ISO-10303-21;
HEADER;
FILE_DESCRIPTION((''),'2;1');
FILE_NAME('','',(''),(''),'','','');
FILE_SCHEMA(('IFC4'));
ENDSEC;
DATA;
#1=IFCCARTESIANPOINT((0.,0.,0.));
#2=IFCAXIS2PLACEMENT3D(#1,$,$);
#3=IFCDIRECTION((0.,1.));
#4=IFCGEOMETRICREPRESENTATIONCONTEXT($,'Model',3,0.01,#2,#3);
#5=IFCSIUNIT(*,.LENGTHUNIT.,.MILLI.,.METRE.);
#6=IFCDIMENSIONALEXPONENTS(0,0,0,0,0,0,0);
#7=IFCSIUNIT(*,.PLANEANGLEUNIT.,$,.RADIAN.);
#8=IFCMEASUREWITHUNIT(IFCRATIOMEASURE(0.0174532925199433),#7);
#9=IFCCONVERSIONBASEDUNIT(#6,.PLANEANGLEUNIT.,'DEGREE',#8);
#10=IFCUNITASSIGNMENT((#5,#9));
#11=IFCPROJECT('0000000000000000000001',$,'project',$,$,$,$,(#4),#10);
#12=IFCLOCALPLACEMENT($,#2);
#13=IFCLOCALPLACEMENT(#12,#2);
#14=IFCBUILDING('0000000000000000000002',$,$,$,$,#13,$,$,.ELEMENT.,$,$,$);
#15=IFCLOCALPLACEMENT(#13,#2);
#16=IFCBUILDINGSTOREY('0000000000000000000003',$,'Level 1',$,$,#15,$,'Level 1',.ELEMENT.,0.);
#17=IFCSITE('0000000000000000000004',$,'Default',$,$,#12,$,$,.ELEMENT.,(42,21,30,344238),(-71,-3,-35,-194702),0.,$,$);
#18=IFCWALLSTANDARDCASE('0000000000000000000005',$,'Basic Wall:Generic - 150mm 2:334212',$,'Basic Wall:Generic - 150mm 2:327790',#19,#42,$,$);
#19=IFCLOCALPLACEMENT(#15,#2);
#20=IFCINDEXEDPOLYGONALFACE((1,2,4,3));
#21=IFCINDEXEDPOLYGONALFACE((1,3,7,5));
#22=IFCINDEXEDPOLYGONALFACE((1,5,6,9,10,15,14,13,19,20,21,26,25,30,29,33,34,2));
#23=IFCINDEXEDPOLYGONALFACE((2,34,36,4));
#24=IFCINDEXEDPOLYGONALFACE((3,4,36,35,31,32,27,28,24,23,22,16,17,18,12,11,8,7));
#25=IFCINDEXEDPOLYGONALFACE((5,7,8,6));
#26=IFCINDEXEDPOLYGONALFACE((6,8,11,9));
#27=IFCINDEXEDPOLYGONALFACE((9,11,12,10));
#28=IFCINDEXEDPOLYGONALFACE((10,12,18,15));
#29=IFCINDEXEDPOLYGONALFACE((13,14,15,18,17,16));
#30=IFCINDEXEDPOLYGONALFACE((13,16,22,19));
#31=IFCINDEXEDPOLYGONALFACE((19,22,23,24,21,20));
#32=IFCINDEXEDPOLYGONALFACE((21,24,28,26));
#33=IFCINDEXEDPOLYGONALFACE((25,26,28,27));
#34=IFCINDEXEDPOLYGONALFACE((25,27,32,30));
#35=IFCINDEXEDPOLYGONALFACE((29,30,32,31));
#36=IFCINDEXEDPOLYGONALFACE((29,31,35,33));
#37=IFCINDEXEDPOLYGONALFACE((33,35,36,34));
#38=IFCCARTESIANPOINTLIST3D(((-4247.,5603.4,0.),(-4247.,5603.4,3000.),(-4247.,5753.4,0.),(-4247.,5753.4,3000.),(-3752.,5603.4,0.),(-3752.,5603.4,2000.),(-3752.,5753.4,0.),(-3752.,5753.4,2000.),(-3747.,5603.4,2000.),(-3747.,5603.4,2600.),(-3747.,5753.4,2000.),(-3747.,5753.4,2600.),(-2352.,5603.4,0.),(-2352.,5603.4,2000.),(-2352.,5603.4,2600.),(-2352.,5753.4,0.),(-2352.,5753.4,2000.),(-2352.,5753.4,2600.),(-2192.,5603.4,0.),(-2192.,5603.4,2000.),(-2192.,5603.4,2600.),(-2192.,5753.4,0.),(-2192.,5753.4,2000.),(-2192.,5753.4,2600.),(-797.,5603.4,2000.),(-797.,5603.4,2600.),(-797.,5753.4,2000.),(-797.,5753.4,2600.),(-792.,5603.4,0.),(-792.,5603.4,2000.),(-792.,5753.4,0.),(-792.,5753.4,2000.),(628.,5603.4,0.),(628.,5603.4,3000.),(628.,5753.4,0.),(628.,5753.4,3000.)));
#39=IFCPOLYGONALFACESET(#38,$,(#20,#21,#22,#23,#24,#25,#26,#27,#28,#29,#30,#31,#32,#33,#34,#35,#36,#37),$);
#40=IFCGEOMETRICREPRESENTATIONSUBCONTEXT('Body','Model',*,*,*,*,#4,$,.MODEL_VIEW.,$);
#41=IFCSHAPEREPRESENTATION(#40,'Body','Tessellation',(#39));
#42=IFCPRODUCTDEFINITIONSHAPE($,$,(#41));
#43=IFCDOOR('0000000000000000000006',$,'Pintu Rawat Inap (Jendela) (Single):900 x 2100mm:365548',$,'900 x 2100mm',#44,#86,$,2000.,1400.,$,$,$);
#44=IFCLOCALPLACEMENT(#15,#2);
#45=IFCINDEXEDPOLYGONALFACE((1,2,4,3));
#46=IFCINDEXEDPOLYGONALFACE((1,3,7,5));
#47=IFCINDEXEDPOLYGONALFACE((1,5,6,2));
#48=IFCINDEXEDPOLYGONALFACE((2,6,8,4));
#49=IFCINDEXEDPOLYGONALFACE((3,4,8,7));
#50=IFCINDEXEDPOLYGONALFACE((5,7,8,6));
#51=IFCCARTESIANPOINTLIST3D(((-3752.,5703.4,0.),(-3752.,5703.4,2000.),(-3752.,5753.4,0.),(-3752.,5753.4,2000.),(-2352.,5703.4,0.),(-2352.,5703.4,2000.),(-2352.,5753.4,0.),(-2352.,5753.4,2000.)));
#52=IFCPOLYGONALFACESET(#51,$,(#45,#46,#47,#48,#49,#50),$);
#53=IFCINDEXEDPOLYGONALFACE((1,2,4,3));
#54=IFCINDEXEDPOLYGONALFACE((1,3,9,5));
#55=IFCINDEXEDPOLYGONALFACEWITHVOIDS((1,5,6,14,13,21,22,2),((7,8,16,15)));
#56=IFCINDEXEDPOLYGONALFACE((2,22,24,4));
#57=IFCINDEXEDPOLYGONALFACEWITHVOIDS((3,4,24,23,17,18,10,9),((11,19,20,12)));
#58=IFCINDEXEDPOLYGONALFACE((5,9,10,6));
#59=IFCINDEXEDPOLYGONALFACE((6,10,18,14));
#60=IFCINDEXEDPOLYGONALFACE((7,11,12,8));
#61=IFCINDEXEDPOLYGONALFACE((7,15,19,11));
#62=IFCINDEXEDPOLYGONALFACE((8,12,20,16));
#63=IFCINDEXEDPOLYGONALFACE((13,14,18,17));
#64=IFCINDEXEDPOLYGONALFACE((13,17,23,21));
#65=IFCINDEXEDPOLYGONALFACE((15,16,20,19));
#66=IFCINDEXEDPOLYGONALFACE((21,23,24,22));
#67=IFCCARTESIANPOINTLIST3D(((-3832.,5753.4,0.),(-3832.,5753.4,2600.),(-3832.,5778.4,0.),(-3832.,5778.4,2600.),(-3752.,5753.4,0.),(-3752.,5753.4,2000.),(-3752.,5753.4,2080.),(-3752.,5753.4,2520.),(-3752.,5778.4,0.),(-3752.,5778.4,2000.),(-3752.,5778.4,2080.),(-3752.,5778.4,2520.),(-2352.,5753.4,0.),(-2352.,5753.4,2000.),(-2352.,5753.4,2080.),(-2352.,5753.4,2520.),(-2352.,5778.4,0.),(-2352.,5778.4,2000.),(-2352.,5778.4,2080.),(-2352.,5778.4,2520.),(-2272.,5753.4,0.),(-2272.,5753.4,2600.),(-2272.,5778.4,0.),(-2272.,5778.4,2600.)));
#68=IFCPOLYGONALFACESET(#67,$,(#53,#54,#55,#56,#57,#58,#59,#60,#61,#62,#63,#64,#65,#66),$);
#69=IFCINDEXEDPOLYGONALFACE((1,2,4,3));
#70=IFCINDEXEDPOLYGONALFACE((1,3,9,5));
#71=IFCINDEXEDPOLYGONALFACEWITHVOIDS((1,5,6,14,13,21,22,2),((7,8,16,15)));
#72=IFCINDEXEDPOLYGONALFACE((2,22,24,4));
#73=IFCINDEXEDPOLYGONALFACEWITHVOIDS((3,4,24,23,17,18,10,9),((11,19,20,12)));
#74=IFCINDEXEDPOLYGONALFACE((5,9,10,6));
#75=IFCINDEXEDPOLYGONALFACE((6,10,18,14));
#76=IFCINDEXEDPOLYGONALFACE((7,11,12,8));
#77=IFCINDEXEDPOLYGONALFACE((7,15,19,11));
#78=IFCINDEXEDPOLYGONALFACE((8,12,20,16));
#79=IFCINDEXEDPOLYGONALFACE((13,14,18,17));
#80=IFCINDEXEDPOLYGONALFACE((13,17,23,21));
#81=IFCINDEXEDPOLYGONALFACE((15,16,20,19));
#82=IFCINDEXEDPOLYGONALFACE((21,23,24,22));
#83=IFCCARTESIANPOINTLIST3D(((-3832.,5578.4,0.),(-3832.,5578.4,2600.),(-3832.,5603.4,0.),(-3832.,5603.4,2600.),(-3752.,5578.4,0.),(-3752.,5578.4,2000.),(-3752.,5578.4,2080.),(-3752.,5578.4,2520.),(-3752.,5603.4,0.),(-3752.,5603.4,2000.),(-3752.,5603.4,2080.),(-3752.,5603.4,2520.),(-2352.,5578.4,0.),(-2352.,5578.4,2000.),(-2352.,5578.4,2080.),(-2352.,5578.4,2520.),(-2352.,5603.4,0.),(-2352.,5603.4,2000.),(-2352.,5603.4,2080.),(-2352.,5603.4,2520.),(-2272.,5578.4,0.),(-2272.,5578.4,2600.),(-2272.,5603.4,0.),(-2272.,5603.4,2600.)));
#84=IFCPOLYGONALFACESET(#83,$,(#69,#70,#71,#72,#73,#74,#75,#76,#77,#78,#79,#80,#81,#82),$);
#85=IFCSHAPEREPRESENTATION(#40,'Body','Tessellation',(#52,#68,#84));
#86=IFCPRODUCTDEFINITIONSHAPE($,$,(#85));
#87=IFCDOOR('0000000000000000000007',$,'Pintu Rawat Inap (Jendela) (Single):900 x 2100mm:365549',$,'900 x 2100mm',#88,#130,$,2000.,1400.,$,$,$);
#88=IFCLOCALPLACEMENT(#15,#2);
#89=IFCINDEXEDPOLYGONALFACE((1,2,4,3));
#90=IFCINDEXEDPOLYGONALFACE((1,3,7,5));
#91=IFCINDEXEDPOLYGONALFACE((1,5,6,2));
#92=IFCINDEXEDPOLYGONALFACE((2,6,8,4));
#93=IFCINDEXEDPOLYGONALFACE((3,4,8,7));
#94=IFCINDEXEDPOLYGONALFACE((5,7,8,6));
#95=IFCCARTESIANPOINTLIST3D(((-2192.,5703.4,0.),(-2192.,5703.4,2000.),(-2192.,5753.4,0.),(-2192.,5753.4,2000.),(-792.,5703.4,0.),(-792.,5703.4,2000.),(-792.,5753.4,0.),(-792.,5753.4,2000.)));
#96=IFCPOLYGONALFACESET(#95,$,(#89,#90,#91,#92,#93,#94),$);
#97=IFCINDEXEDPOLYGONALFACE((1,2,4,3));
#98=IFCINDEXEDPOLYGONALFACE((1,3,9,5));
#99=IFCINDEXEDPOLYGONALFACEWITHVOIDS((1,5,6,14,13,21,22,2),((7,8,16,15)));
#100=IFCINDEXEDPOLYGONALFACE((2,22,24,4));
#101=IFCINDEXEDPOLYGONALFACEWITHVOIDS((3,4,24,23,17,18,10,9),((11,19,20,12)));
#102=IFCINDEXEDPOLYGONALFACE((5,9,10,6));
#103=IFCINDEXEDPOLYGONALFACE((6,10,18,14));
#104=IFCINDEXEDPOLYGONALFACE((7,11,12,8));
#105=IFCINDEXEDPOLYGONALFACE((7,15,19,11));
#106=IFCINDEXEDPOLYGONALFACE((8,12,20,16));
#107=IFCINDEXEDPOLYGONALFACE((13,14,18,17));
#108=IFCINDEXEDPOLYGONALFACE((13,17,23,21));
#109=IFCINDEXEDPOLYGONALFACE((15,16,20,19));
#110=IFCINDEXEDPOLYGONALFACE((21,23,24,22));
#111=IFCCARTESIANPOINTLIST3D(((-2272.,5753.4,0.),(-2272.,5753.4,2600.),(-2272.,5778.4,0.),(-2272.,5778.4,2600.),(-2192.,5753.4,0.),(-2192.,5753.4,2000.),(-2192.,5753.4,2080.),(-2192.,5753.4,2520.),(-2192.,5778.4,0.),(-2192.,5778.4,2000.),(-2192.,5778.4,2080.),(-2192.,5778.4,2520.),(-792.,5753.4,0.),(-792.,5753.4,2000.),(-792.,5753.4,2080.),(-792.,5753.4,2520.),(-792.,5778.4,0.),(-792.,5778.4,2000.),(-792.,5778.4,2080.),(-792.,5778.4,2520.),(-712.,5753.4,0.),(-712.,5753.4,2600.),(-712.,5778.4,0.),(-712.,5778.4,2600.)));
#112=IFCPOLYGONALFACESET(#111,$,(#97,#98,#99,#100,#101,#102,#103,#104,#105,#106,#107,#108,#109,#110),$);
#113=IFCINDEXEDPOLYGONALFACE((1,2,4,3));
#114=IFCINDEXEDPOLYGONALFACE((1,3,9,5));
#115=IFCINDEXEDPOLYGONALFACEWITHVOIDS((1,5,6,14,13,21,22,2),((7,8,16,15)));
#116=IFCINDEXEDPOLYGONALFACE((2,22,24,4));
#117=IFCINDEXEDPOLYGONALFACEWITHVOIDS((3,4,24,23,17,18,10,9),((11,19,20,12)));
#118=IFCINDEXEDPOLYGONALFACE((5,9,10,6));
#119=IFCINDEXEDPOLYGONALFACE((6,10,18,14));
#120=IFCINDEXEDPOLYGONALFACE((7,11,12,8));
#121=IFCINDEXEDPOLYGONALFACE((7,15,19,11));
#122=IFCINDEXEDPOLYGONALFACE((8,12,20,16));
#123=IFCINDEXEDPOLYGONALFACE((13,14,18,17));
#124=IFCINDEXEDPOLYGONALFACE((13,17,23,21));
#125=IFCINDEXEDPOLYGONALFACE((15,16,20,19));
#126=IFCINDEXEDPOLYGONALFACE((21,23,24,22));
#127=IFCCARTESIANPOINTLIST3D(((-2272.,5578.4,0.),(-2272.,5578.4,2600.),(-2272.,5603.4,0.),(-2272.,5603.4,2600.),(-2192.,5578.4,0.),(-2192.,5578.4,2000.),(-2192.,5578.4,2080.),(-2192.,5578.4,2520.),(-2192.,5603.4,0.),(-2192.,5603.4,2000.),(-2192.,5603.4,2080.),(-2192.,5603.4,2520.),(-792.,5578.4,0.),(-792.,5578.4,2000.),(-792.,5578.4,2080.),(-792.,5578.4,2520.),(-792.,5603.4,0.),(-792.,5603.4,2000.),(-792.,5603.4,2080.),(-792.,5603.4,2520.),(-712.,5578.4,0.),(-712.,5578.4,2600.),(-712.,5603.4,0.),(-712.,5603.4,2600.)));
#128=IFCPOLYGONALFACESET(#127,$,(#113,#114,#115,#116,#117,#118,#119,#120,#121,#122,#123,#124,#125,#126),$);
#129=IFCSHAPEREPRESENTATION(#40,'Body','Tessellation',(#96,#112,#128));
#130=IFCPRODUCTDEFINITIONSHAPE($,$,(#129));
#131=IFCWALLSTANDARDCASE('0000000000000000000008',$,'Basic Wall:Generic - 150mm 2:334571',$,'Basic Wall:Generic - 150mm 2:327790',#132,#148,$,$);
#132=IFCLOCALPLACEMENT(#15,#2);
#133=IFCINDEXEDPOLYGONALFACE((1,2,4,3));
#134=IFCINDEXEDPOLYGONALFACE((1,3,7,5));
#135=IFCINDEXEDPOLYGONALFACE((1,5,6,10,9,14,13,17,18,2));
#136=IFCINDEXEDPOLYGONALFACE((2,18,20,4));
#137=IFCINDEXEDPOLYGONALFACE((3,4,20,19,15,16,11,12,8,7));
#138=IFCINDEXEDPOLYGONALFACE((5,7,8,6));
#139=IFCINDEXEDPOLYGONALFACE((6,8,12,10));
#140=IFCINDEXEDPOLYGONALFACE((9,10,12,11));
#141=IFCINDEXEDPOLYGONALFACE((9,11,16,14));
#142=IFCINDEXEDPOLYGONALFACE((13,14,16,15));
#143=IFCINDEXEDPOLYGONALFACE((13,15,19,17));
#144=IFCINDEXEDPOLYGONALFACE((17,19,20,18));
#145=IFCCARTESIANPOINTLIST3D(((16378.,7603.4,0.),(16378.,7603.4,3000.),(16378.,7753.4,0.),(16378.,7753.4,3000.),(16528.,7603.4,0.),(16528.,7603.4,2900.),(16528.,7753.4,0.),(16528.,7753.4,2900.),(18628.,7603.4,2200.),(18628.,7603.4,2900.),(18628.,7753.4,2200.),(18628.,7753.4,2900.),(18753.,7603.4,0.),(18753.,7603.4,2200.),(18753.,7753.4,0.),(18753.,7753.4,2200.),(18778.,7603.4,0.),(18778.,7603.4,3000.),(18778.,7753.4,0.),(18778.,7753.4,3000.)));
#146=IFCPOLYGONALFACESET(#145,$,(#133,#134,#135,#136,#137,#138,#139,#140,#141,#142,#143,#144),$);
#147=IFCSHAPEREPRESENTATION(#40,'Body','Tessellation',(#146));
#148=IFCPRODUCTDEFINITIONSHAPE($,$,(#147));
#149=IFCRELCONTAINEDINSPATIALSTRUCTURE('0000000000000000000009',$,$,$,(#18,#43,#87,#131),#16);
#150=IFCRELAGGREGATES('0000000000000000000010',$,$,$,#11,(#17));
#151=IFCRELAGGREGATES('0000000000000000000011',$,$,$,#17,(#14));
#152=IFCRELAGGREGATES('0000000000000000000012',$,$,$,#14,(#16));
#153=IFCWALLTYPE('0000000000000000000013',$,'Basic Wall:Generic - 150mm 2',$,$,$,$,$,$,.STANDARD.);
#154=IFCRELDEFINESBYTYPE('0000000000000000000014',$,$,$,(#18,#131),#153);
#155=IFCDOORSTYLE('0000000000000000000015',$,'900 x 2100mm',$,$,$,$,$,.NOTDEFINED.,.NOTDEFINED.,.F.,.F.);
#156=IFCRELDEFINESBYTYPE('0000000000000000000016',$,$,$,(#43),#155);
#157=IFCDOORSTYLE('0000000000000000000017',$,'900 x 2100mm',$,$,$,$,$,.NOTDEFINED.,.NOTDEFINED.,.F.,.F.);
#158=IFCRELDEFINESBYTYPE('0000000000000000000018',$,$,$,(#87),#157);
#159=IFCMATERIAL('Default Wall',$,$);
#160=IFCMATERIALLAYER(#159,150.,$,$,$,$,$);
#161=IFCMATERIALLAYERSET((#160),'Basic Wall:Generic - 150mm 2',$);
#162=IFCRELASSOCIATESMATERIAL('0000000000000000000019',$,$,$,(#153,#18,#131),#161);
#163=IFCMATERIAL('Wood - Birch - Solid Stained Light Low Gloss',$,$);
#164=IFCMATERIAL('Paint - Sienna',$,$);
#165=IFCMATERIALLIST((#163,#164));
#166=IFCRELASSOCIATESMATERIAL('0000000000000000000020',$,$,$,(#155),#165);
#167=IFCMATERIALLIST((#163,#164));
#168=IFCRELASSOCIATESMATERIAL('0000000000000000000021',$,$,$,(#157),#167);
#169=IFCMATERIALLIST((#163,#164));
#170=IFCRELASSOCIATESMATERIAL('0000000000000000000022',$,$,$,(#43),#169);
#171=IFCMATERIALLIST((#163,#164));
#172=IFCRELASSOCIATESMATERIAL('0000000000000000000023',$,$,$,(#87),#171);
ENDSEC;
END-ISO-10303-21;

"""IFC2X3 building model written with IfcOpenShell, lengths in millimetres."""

from ifc_helpers import new_model, entity, si_unit, converted_unit, direction, frame, frame_2d, origin, place, context, subcontext, project, spatial, polyline, rectangle, outline, extrude, source, transform, mapped, material, material_list, layer, layer_set, layer_usage, type_object, type_shapes, element, fill, save


model = new_model("IFC2X3")

# Units and contexts
model_context = context("Model", 3, precision=0.01, world=origin(), true_north=direction((0.0, 1.0)))
body_context = subcontext(model_context, "Body", "Model", "MODEL_VIEW")
ifc_project = project(units=[si_unit("LENGTHUNIT", "METRE", prefix="MILLI"), converted_unit("PLANEANGLEUNIT", "DEGREE", entity("IfcRatioMeasure", 0.0174532925199433), si_unit("PLANEANGLEUNIT", "RADIAN"), dimensions=[0, 0, 0, 0, 0, 0, 0])], contexts=[model_context])

# Site, building, storey
site_placement = place(None, origin())
site = spatial("IfcSite", under=ifc_project, at=site_placement, Name="Default", CompositionType="ELEMENT", RefLatitude=(42, 21, 30, 344238), RefLongitude=(-71, -3, -35, -194702), RefElevation=0.0)
building_placement = place(site_placement, origin())
building = spatial("IfcBuilding", under=site, at=building_placement, CompositionType="ELEMENT")
storey_placement = place(building_placement, origin())
storey = spatial("IfcBuildingStorey", under=building, at=storey_placement, Name="Level 1", LongName="Level 1", CompositionType="ELEMENT", Elevation=0.0)

# Shared definitions
ifc_material_1 = material(Name="Default Wall")
ifc_layer = layer(ifc_material_1, 150.0)
ifc_layer_set = layer_set([ifc_layer], Name="Basic Wall:Generic - 150mm 2")
wall_type = type_object("IfcWallType", Name="Basic Wall:Generic - 150mm 2", PredefinedType="STANDARD", material=ifc_layer_set)
ifc_material_2 = material(Name="Wood - Birch - Solid Stained Light Low Gloss")
ifc_material_3 = material(Name="Paint - Sienna")
ifc_material_list_1 = material_list([ifc_material_2, ifc_material_3])
door_style_1 = type_object("IfcDoorStyle", Name="900 x 2100mm", ConstructionType="NOTDEFINED", OperationType="NOTDEFINED", ParameterTakesPrecedence=False, Sizeable=False, material=ifc_material_list_1)
shared_shape_1 = source(origin(), body_context, "Body", "SweptSolid", [
    extrude(rectangle(XDim=50.0, YDim=1400.0, at=frame_2d((0.0, 0.0), x_axis=(1.0, 0.0))), frame((700.0, 125.0, 0.0), z_axis=(0.0, 0.0, 1.0), x_axis=(0.0, 1.0, 0.0)), (0.0, 0.0, 1.0), 2000.0),
    extrude(outline(polyline([(-780.0, -1450.0), (780.0, -1450.0), (780.0, 1150.0), (700.0, 1150.0), (700.0, -850.0), (-700.0, -850.0), (-700.0, 1150.0), (-780.0, 1150.0), (-780.0, -1450.0)]), holes=[polyline([(700.0, -1370.0), (-700.0, -1370.0), (-700.0, -930.0), (700.0, -930.0), (700.0, -1370.0)])]), frame((700.0, 150.0, 1150.0), z_axis=(0.0, 1.0, 0.0), x_axis=(1.0, 0.0, 0.0)), (0.0, 0.0, 1.0), 25.0),
    extrude(outline(polyline([(-1450.0, -780.0), (1150.0, -780.0), (1150.0, -700.0), (-850.0, -700.0), (-850.0, 700.0), (1150.0, 700.0), (1150.0, 780.0), (-1450.0, 780.0), (-1450.0, -780.0)]), holes=[polyline([(-930.0, -700.0), (-1370.0, -700.0), (-1370.0, 700.0), (-930.0, 700.0), (-930.0, -700.0)])]), frame((700.0, -25.0, 1150.0), z_axis=(0.0, 1.0, 0.0), x_axis=(0.0, 0.0, -1.0)), (0.0, 0.0, 1.0), 25.0),
])
type_shapes(door_style_1, [shared_shape_1])
ifc_material_list_2 = material_list([ifc_material_2, ifc_material_3])
door_style_2 = type_object("IfcDoorStyle", Name="900 x 2100mm", ConstructionType="NOTDEFINED", OperationType="NOTDEFINED", ParameterTakesPrecedence=False, Sizeable=False, material=ifc_material_list_2)
shared_shape_2 = source(origin(), body_context, "Body", "SweptSolid", [
    extrude(rectangle(XDim=1400.0, YDim=50.0, at=frame_2d((0.0, 0.0), x_axis=(1.0, 0.0))), frame((700.0, 125.0, 0.0)), (0.0, 0.0, 1.0), 2000.0),
    extrude(outline(polyline([(-780.0, -1450.0), (780.0, -1450.0), (780.0, 1150.0), (700.0, 1150.0), (700.0, -850.0), (-700.0, -850.0), (-700.0, 1150.0), (-780.0, 1150.0), (-780.0, -1450.0)]), holes=[polyline([(700.0, -1370.0), (-700.0, -1370.0), (-700.0, -930.0), (700.0, -930.0), (700.0, -1370.0)])]), frame((700.0, 175.0, 1150.0), z_axis=(0.0, -1.0, 0.0), x_axis=(-1.0, 0.0, 0.0)), (0.0, 0.0, 1.0), 25.0),
    extrude(outline(polyline([(-1450.0, -780.0), (1150.0, -780.0), (1150.0, -700.0), (-850.0, -700.0), (-850.0, 700.0), (1150.0, 700.0), (1150.0, 780.0), (-1450.0, 780.0), (-1450.0, -780.0)]), holes=[polyline([(-930.0, -700.0), (-1370.0, -700.0), (-1370.0, 700.0), (-930.0, 700.0), (-930.0, -700.0)])]), frame((700.0, 0.0, 1150.0), z_axis=(0.0, -1.0, 0.0), x_axis=(0.0, 0.0, -1.0)), (0.0, 0.0, 1.0), 25.0),
])
type_shapes(door_style_2, [shared_shape_2])

# Wall, openings, doors
ifc_layer_usage_1 = layer_usage(ifc_layer_set, "AXIS2", "NEGATIVE", 75.0)
wall_1_placement = place(storey_placement, frame((628.0, 5678.4, 0.0), z_axis=(0.0, 0.0, 1.0), x_axis=(-1.0, 0.0, 0.0)))
wall_1 = element("IfcWallStandardCase", 1, at=wall_1_placement, inside=storey, type_object=wall_type, material=ifc_layer_usage_1, Name="Basic Wall:Generic - 150mm 2:334212", ObjectType="Basic Wall:Generic - 150mm 2:327790", context=body_context, shape_type="SweptSolid", body=[
    extrude(rectangle(XDim=4875.0, YDim=150.0, at=frame_2d((2437.5, 0.0), x_axis=(-1.0, 0.0))), origin(), (0.0, 0.0, 1.0), 3000.0),
])
opening_1_placement = place(wall_1_placement, origin())
element("IfcOpeningElement", 2, at=opening_1_placement, cuts=wall_1, ObjectType="Opening", context=body_context, shape_type="SweptSolid", body=[
    extrude(rectangle(XDim=2600.0, YDim=1395.0, at=frame_2d((0.0, 0.0), x_axis=(0.0, 1.0))), frame((2122.5, 75.0, 1300.0), z_axis=(0.0, -1.0, 0.0), x_axis=(1.0, 0.0, 0.0)), (0.0, 0.0, 1.0), 150.0),
])
opening_2_placement = place(wall_1_placement, origin())
element("IfcOpeningElement", 3, at=opening_2_placement, cuts=wall_1, ObjectType="Opening", context=body_context, shape_type="SweptSolid", body=[
    extrude(rectangle(XDim=2600.0, YDim=1395.0, at=frame_2d((0.0, 0.0), x_axis=(0.0, 1.0))), frame((3677.5, 75.0, 1300.0), z_axis=(0.0, -1.0, 0.0), x_axis=(1.0, 0.0, 0.0)), (0.0, 0.0, 1.0), 150.0),
])
opening_3_placement = place(wall_1_placement, frame((2820.0, 75.0, 0.0)))
opening_3 = element("IfcOpeningElement", 4, at=opening_3_placement, cuts=wall_1, ObjectType="Opening", context=body_context, shape_type="SweptSolid", body=[
    extrude(rectangle(XDim=1400.0, YDim=2000.0, at=frame_2d((1000.0, 700.0), x_axis=(0.0, -1.0))), frame((0.0, 0.0, 0.0), z_axis=(0.0, -1.0, 0.0), x_axis=(0.0, 0.0, 1.0)), (0.0, 0.0, 1.0), 150.0),
])
opening_4_placement = place(wall_1_placement, frame((4380.0, 75.0, 0.0)))
opening_4 = element("IfcOpeningElement", 5, at=opening_4_placement, cuts=wall_1, ObjectType="Opening", context=body_context, shape_type="SweptSolid", body=[
    extrude(rectangle(XDim=1400.0, YDim=2000.0, at=frame_2d((1000.0, 700.0), x_axis=(0.0, 1.0))), frame((0.0, 0.0, 0.0), z_axis=(0.0, -1.0, 0.0), x_axis=(0.0, 0.0, 1.0)), (0.0, 0.0, 1.0), 150.0),
])
ifc_material_list_3 = material_list([ifc_material_2, ifc_material_3])
door_1_placement = place(opening_4_placement, frame((0.0, 0.0, 0.0), z_axis=(0.0, 0.0, 1.0), x_axis=(-1.0, 0.0, 0.0)))
door_1 = element("IfcDoor", 6, at=door_1_placement, inside=storey, type_object=door_style_1, material=ifc_material_list_3, Name="Pintu Rawat Inap (Jendela) (Single):900 x 2100mm:365548", ObjectType="900 x 2100mm", OverallHeight=2000.0, OverallWidth=1400.0, context=body_context, shape_type="MappedRepresentation", body=[
    mapped(shared_shape_1, transform((0.0, 0.0, 0.0), scale=1.0)),
])
fill(opening_4, door_1)
ifc_material_list_4 = material_list([ifc_material_2, ifc_material_3])
door_2_placement = place(opening_3_placement, frame((0.0, 0.0, 0.0), z_axis=(0.0, 0.0, 1.0), x_axis=(-1.0, 0.0, 0.0)))
door_2 = element("IfcDoor", 7, at=door_2_placement, inside=storey, type_object=door_style_2, material=ifc_material_list_4, Name="Pintu Rawat Inap (Jendela) (Single):900 x 2100mm:365549", ObjectType="900 x 2100mm", OverallHeight=2000.0, OverallWidth=1400.0, context=body_context, shape_type="MappedRepresentation", body=[
    mapped(shared_shape_2, transform((0.0, 0.0, 0.0), scale=1.0)),
])
fill(opening_3, door_2)

# Wall, openings
ifc_layer_usage_2 = layer_usage(ifc_layer_set, "AXIS2", "NEGATIVE", 75.0)
wall_2_placement = place(storey_placement, frame((18778.0, 7678.4, 0.0), z_axis=(0.0, 0.0, 1.0), x_axis=(-1.0, 0.0, 0.0)))
wall_2 = element("IfcWallStandardCase", 8, at=wall_2_placement, inside=storey, type_object=wall_type, material=ifc_layer_usage_2, Name="Basic Wall:Generic - 150mm 2:334571", ObjectType="Basic Wall:Generic - 150mm 2:327790", context=body_context, shape_type="SweptSolid", body=[
    extrude(rectangle(XDim=2400.0, YDim=150.0, at=frame_2d((1200.0, 0.0), x_axis=(-1.0, 0.0))), origin(), (0.0, 0.0, 1.0), 3000.0),
])
opening_5_placement = place(wall_2_placement, origin())
element("IfcOpeningElement", 9, at=opening_5_placement, cuts=wall_2, ObjectType="Opening", context=body_context, shape_type="SweptSolid", body=[
    extrude(rectangle(XDim=2900.0, YDim=2100.0, at=frame_2d((0.0, 0.0), x_axis=(0.0, 1.0))), frame((1200.0, 75.0, 1450.0), z_axis=(0.0, -1.0, 0.0), x_axis=(1.0, 0.0, 0.0)), (0.0, 0.0, 1.0), 150.0),
])
opening_6_placement = place(wall_2_placement, frame((2225.0, 75.0, 0.0)))
element("IfcOpeningElement", 10, at=opening_6_placement, cuts=wall_2, ObjectType="Opening", context=body_context, shape_type="SweptSolid", body=[
    extrude(rectangle(XDim=2200.0, YDim=2200.0, at=frame_2d((1100.0, 1100.0), x_axis=(1.0, 0.0))), frame((0.0, 0.0, 0.0), z_axis=(0.0, -1.0, 0.0), x_axis=(0.0, 0.0, 1.0)), (0.0, 0.0, 1.0), 150.0),
])

save(model, "model.ifc")
